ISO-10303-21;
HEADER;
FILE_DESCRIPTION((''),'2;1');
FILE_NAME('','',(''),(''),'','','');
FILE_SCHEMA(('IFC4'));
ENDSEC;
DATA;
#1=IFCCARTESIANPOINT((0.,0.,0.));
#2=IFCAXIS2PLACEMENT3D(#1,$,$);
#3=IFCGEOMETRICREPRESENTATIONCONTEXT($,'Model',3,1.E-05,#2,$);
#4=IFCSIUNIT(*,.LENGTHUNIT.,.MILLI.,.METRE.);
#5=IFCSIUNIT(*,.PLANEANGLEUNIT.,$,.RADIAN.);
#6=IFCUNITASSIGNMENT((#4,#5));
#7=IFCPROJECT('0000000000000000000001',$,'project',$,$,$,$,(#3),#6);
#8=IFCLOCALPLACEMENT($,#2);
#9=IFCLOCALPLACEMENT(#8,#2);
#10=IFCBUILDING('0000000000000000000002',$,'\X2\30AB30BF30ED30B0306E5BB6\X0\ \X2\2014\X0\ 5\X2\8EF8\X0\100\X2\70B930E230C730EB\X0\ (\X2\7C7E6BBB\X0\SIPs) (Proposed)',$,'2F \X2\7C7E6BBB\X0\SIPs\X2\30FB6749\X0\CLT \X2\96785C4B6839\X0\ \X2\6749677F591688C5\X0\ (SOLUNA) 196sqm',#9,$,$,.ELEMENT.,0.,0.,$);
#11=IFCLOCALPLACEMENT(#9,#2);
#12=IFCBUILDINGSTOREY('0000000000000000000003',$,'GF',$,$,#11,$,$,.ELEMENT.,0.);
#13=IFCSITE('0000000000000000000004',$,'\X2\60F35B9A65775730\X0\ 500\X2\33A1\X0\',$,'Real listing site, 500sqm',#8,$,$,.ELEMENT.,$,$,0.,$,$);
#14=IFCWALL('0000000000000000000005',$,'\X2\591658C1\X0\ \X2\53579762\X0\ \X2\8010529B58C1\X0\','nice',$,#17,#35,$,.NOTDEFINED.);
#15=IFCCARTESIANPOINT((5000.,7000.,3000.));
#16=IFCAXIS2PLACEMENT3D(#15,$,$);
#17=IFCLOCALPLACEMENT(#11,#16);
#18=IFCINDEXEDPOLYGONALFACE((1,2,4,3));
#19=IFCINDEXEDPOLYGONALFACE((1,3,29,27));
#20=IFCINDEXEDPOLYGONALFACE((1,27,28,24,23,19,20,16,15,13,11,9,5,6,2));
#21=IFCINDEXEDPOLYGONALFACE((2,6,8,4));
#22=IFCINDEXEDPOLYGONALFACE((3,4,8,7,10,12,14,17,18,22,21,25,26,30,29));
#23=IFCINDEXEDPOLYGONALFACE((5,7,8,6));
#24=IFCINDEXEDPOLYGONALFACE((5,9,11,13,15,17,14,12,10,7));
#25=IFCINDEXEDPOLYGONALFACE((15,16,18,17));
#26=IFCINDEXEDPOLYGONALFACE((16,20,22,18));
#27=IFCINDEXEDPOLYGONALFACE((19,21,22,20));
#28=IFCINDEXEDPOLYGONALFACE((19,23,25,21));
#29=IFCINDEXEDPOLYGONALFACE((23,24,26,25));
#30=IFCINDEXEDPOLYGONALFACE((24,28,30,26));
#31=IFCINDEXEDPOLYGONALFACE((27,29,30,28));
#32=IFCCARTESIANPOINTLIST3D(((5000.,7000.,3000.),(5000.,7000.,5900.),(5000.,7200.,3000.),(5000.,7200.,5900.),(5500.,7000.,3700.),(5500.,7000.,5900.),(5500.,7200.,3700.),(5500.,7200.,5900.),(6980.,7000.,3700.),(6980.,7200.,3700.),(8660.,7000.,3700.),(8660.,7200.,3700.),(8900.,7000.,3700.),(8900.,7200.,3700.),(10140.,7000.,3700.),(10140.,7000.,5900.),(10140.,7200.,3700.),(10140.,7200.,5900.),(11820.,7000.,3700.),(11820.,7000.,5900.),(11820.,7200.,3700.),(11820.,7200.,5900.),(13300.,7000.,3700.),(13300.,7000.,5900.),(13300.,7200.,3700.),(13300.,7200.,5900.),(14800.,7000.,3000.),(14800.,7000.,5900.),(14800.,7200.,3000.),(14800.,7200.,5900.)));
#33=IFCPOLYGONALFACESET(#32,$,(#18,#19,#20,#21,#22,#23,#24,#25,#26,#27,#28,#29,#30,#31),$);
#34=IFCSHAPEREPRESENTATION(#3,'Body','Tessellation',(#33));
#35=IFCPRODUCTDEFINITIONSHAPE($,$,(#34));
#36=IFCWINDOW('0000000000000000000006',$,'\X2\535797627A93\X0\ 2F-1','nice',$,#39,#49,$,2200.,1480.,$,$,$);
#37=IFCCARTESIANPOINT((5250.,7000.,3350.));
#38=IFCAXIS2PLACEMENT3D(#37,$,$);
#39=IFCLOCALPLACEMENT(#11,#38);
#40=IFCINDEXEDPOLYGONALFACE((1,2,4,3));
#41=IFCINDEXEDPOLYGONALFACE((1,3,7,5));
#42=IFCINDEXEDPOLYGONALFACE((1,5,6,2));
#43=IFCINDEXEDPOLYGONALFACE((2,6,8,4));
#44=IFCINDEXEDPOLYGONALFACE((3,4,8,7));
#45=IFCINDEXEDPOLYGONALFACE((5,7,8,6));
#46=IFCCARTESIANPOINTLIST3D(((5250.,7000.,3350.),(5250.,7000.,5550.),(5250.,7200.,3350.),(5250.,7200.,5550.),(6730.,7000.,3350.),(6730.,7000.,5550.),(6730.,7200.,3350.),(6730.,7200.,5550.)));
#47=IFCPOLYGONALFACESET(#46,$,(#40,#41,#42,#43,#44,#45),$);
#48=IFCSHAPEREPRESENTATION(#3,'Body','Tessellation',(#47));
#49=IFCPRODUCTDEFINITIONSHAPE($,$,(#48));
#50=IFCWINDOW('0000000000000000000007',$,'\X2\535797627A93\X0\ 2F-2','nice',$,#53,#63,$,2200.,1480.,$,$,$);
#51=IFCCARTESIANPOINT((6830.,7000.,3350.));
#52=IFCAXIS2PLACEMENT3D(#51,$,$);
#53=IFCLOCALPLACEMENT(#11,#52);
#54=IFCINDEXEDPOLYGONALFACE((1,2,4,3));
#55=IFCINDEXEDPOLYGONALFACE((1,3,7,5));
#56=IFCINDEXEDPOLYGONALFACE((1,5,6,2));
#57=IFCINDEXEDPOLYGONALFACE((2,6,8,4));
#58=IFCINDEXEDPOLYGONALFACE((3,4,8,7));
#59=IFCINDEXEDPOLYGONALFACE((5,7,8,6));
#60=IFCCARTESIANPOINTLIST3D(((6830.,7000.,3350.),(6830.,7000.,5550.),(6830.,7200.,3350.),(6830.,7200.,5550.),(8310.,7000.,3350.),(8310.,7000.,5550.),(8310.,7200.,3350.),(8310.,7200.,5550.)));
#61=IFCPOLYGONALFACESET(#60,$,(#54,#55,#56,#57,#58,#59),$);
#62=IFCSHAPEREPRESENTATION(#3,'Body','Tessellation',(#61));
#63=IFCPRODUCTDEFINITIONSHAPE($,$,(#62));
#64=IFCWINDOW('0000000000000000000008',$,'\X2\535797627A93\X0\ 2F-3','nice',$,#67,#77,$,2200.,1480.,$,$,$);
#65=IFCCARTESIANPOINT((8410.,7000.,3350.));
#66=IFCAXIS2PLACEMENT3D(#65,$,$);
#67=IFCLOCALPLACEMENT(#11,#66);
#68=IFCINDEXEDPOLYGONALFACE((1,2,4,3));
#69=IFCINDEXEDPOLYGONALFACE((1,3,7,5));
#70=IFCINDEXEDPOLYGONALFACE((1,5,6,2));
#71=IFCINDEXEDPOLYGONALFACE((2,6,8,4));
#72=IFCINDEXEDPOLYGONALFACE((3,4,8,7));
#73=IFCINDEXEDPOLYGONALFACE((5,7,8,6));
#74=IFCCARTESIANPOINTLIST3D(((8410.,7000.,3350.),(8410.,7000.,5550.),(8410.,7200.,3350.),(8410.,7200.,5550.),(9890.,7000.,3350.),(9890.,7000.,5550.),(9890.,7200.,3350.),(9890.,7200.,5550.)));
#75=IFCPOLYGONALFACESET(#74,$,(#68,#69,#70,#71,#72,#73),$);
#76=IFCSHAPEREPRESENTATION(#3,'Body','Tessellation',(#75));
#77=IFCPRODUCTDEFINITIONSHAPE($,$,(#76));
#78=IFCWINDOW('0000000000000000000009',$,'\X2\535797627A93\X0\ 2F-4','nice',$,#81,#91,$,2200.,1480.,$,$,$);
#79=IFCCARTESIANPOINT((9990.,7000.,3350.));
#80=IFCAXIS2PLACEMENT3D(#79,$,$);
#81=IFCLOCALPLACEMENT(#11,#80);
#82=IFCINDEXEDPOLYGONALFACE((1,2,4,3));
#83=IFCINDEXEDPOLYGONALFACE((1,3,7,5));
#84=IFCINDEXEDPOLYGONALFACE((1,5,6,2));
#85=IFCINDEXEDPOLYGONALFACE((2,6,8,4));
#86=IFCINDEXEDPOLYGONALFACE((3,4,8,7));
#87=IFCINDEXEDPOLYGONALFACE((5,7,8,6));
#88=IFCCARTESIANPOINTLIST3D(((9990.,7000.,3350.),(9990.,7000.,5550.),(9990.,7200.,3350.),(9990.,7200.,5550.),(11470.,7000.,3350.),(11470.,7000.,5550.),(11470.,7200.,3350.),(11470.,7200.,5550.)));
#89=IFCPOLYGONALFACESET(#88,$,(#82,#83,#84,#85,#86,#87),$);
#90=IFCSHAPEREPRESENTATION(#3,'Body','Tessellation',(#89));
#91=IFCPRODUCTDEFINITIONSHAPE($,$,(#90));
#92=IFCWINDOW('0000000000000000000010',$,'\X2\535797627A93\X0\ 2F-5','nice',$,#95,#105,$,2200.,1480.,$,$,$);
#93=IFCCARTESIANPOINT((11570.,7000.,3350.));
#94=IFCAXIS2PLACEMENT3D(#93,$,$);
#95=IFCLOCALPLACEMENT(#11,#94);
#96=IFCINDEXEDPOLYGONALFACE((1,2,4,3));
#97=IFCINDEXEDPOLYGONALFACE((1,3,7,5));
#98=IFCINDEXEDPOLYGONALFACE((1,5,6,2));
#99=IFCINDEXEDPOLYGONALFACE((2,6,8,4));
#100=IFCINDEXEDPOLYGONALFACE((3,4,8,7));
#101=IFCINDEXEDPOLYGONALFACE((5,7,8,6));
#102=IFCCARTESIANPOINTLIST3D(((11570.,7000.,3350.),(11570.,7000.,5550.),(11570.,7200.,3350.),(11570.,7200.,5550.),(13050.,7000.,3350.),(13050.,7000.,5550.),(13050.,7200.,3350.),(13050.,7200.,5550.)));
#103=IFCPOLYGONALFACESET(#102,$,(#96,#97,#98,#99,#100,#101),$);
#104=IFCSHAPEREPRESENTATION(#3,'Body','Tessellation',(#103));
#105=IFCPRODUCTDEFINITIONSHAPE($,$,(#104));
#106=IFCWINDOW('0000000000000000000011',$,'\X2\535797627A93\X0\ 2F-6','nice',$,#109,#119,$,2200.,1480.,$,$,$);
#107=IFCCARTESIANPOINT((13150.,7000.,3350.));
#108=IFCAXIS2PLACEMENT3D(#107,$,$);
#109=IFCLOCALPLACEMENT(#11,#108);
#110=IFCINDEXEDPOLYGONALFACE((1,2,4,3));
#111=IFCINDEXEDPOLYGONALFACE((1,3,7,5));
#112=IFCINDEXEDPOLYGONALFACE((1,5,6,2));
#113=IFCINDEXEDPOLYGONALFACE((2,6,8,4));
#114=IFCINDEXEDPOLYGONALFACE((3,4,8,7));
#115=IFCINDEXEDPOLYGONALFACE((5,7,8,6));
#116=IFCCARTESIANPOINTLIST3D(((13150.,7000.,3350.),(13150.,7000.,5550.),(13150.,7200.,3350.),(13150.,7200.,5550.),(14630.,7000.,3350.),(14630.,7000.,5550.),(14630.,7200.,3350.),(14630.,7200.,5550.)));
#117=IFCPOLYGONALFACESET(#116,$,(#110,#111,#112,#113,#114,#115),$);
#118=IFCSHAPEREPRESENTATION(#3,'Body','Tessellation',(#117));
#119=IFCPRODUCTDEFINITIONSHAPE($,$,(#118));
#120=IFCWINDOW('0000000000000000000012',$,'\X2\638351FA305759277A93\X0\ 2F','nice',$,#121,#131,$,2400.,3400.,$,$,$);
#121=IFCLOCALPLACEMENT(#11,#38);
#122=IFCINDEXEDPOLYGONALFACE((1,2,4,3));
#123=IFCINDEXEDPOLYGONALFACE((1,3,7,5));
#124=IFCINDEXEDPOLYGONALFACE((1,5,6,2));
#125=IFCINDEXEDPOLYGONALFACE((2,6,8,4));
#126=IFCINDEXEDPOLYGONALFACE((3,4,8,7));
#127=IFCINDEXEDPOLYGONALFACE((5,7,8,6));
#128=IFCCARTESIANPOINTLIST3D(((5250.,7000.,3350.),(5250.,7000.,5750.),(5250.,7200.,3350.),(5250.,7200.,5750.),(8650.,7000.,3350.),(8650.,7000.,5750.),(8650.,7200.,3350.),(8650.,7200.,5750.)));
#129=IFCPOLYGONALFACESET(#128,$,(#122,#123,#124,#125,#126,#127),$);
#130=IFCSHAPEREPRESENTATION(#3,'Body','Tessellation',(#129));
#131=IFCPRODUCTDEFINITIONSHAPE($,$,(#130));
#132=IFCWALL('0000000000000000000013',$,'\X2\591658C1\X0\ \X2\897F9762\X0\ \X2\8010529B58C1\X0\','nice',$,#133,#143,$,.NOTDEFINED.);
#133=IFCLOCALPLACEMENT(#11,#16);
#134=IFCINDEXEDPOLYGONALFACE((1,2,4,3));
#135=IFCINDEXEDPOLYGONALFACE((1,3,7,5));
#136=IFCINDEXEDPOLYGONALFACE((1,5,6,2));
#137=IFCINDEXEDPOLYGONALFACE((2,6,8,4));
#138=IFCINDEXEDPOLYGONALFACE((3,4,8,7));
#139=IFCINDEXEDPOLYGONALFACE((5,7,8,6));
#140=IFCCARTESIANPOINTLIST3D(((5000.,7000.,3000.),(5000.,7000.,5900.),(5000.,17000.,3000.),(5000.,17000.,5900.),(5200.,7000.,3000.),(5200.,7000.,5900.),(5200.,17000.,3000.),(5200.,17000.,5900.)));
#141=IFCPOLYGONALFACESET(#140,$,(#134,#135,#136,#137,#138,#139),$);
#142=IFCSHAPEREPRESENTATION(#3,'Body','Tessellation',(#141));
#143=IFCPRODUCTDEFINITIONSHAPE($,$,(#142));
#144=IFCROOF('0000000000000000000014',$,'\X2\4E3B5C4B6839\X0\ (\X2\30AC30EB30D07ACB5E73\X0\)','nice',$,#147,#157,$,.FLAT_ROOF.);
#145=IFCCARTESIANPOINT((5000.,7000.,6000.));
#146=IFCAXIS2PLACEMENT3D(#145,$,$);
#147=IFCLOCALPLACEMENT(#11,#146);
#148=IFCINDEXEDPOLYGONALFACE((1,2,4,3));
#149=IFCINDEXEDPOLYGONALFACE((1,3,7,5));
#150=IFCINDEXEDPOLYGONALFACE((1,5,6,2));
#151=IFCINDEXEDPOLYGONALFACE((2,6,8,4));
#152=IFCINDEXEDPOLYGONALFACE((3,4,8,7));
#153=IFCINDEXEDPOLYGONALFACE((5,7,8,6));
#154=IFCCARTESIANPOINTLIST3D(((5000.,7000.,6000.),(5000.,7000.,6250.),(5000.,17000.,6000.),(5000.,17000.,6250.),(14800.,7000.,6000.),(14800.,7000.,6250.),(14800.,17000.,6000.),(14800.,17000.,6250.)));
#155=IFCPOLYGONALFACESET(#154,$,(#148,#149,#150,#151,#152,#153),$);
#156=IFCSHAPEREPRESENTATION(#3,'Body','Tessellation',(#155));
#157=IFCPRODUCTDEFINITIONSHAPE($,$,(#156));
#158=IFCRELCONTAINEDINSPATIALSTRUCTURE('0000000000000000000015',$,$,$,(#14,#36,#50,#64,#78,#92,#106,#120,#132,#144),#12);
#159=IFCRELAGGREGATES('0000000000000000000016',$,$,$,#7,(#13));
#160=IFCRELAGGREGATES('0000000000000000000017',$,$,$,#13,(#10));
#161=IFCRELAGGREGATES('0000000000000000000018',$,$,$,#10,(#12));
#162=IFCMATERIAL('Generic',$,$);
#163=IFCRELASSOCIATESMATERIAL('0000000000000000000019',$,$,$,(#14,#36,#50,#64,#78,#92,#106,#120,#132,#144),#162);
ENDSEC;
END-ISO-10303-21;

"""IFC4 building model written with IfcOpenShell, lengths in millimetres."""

from ifc_helpers import new_model, si_unit, frame, frame_2d, origin, place, context, project, spatial, rectangle, extrude, material, element, fill, save


model = new_model("IFC4")

# Units and contexts
model_context = context("Model", 3, precision=1e-05, world=origin())
ifc_project = project(units=[si_unit("LENGTHUNIT", "METRE", prefix="MILLI"), si_unit("PLANEANGLEUNIT", "RADIAN")], contexts=[model_context])

# Site, building, storey
site_placement = place(None, origin())
site = spatial("IfcSite", under=ifc_project, at=site_placement, Name="想定敷地 500㎡", ObjectType="Real listing site, 500sqm", CompositionType="ELEMENT", RefElevation=0.0)
building_placement = place(site_placement, origin())
building = spatial("IfcBuilding", under=site, at=building_placement, Name="カタログの家 — 5軸100点モデル (籾殻SIPs) (Proposed)", ObjectType="2F 籾殻SIPs・杉CLT 陸屋根 杉板外装 (SOLUNA) 196sqm", CompositionType="ELEMENT", ElevationOfRefHeight=0.0, ElevationOfTerrain=0.0)
storey_placement = place(building_placement, origin())
storey = spatial("IfcBuildingStorey", under=building, at=storey_placement, Name="GF", CompositionType="ELEMENT", Elevation=0.0)

# Shared definitions
ifc_material = material(Name="Generic")

# Wall, openings, windows
wall_1_placement = place(storey_placement, frame((5000.0, 7000.0, 3000.0)))
wall_1 = element("IfcWall", 1, at=wall_1_placement, inside=storey, material=ifc_material, Name="外壁 南面 耐力壁", Description="nice", PredefinedType="NOTDEFINED", context=model_context, shape_type="SweptSolid", body=[
    extrude(rectangle(XDim=9800.0, YDim=200.0, at=frame_2d((4900.0, 100.0))), frame((5000.0, 7000.0, 3000.0)), (0.0, 0.0, 1.0), 2900.0),
])
opening_1_placement = place(storey_placement, frame((5250.0, 7000.0, 3350.0)))
opening_1 = element("IfcOpeningElement", 2, at=opening_1_placement, cuts=wall_1, PredefinedType="NOTDEFINED", context=model_context, shape_type="SweptSolid", body=[
    extrude(rectangle(XDim=1480.0, YDim=200.0, at=frame_2d((740.0, 100.0))), frame((5250.0, 7000.0, 3350.0)), (0.0, 0.0, 1.0), 2200.0),
])
opening_2_placement = place(storey_placement, frame((6830.0, 7000.0, 3350.0)))
opening_2 = element("IfcOpeningElement", 3, at=opening_2_placement, cuts=wall_1, PredefinedType="NOTDEFINED", context=model_context, shape_type="SweptSolid", body=[
    extrude(rectangle(XDim=1480.0, YDim=200.0, at=frame_2d((740.0, 100.0))), frame((6830.0, 7000.0, 3350.0)), (0.0, 0.0, 1.0), 2200.0),
])
opening_3_placement = place(storey_placement, frame((8410.0, 7000.0, 3350.0)))
opening_3 = element("IfcOpeningElement", 4, at=opening_3_placement, cuts=wall_1, PredefinedType="NOTDEFINED", context=model_context, shape_type="SweptSolid", body=[
    extrude(rectangle(XDim=1480.0, YDim=200.0, at=frame_2d((740.0, 100.0))), frame((8410.0, 7000.0, 3350.0)), (0.0, 0.0, 1.0), 2200.0),
])
opening_4_placement = place(storey_placement, frame((9990.0, 7000.0, 3350.0)))
opening_4 = element("IfcOpeningElement", 5, at=opening_4_placement, cuts=wall_1, PredefinedType="NOTDEFINED", context=model_context, shape_type="SweptSolid", body=[
    extrude(rectangle(XDim=1480.0, YDim=200.0, at=frame_2d((740.0, 100.0))), frame((9990.0, 7000.0, 3350.0)), (0.0, 0.0, 1.0), 2200.0),
])
opening_5_placement = place(storey_placement, frame((11570.0, 7000.0, 3350.0)))
opening_5 = element("IfcOpeningElement", 6, at=opening_5_placement, cuts=wall_1, PredefinedType="NOTDEFINED", context=model_context, shape_type="SweptSolid", body=[
    extrude(rectangle(XDim=1480.0, YDim=200.0, at=frame_2d((740.0, 100.0))), frame((11570.0, 7000.0, 3350.0)), (0.0, 0.0, 1.0), 2200.0),
])
opening_6_placement = place(storey_placement, frame((13150.0, 7000.0, 3350.0)))
opening_6 = element("IfcOpeningElement", 7, at=opening_6_placement, cuts=wall_1, PredefinedType="NOTDEFINED", context=model_context, shape_type="SweptSolid", body=[
    extrude(rectangle(XDim=1480.0, YDim=200.0, at=frame_2d((740.0, 100.0))), frame((13150.0, 7000.0, 3350.0)), (0.0, 0.0, 1.0), 2200.0),
])
opening_7_placement = place(storey_placement, frame((5250.0, 7000.0, 3350.0)))
opening_7 = element("IfcOpeningElement", 8, at=opening_7_placement, cuts=wall_1, PredefinedType="NOTDEFINED", context=model_context, shape_type="SweptSolid", body=[
    extrude(rectangle(XDim=3400.0, YDim=200.0, at=frame_2d((1700.0, 100.0))), frame((5250.0, 7000.0, 3350.0)), (0.0, 0.0, 1.0), 2400.0),
])
window_1_placement = place(storey_placement, frame((5250.0, 7000.0, 3350.0)))
window_1 = element("IfcWindow", 9, at=window_1_placement, inside=storey, material=ifc_material, Name="南面窓 2F-1", Description="nice", OverallHeight=2200.0, OverallWidth=1480.0, context=model_context, shape_type="SweptSolid", body=[
    extrude(rectangle(XDim=1480.0, YDim=200.0, at=frame_2d((740.0, 100.0))), frame((5250.0, 7000.0, 3350.0)), (0.0, 0.0, 1.0), 2200.0),
])
fill(opening_1, window_1)
window_2_placement = place(storey_placement, frame((6830.0, 7000.0, 3350.0)))
window_2 = element("IfcWindow", 10, at=window_2_placement, inside=storey, material=ifc_material, Name="南面窓 2F-2", Description="nice", OverallHeight=2200.0, OverallWidth=1480.0, context=model_context, shape_type="SweptSolid", body=[
    extrude(rectangle(XDim=1480.0, YDim=200.0, at=frame_2d((740.0, 100.0))), frame((6830.0, 7000.0, 3350.0)), (0.0, 0.0, 1.0), 2200.0),
])
fill(opening_2, window_2)
window_3_placement = place(storey_placement, frame((8410.0, 7000.0, 3350.0)))
window_3 = element("IfcWindow", 11, at=window_3_placement, inside=storey, material=ifc_material, Name="南面窓 2F-3", Description="nice", OverallHeight=2200.0, OverallWidth=1480.0, context=model_context, shape_type="SweptSolid", body=[
    extrude(rectangle(XDim=1480.0, YDim=200.0, at=frame_2d((740.0, 100.0))), frame((8410.0, 7000.0, 3350.0)), (0.0, 0.0, 1.0), 2200.0),
])
fill(opening_3, window_3)
window_4_placement = place(storey_placement, frame((9990.0, 7000.0, 3350.0)))
window_4 = element("IfcWindow", 12, at=window_4_placement, inside=storey, material=ifc_material, Name="南面窓 2F-4", Description="nice", OverallHeight=2200.0, OverallWidth=1480.0, context=model_context, shape_type="SweptSolid", body=[
    extrude(rectangle(XDim=1480.0, YDim=200.0, at=frame_2d((740.0, 100.0))), frame((9990.0, 7000.0, 3350.0)), (0.0, 0.0, 1.0), 2200.0),
])
fill(opening_4, window_4)
window_5_placement = place(storey_placement, frame((11570.0, 7000.0, 3350.0)))
window_5 = element("IfcWindow", 13, at=window_5_placement, inside=storey, material=ifc_material, Name="南面窓 2F-5", Description="nice", OverallHeight=2200.0, OverallWidth=1480.0, context=model_context, shape_type="SweptSolid", body=[
    extrude(rectangle(XDim=1480.0, YDim=200.0, at=frame_2d((740.0, 100.0))), frame((11570.0, 7000.0, 3350.0)), (0.0, 0.0, 1.0), 2200.0),
])
fill(opening_5, window_5)
window_6_placement = place(storey_placement, frame((13150.0, 7000.0, 3350.0)))
window_6 = element("IfcWindow", 14, at=window_6_placement, inside=storey, material=ifc_material, Name="南面窓 2F-6", Description="nice", OverallHeight=2200.0, OverallWidth=1480.0, context=model_context, shape_type="SweptSolid", body=[
    extrude(rectangle(XDim=1480.0, YDim=200.0, at=frame_2d((740.0, 100.0))), frame((13150.0, 7000.0, 3350.0)), (0.0, 0.0, 1.0), 2200.0),
])
fill(opening_6, window_6)
window_7_placement = place(storey_placement, frame((5250.0, 7000.0, 3350.0)))
window_7 = element("IfcWindow", 15, at=window_7_placement, inside=storey, material=ifc_material, Name="掃出し大窓 2F", Description="nice", OverallHeight=2400.0, OverallWidth=3400.0, context=model_context, shape_type="SweptSolid", body=[
    extrude(rectangle(XDim=3400.0, YDim=200.0, at=frame_2d((1700.0, 100.0))), frame((5250.0, 7000.0, 3350.0)), (0.0, 0.0, 1.0), 2400.0),
])
fill(opening_7, window_7)

# Wall
wall_2_placement = place(storey_placement, frame((5000.0, 7000.0, 3000.0)))
element("IfcWall", 16, at=wall_2_placement, inside=storey, material=ifc_material, Name="外壁 西面 耐力壁", Description="nice", PredefinedType="NOTDEFINED", context=model_context, shape_type="SweptSolid", body=[
    extrude(rectangle(XDim=200.0, YDim=10000.0, at=frame_2d((100.0, 5000.0))), frame((5000.0, 7000.0, 3000.0)), (0.0, 0.0, 1.0), 2900.0),
])

# Roof
roof_placement = place(storey_placement, frame((5000.0, 7000.0, 6000.0)))
element("IfcRoof", 17, at=roof_placement, inside=storey, material=ifc_material, Name="主屋根 (ガルバ立平)", Description="nice", PredefinedType="FLAT_ROOF", context=model_context, shape_type="SweptSolid", body=[
    extrude(rectangle(XDim=9800.0, YDim=10000.0, at=frame_2d((4900.0, 5000.0))), frame((5000.0, 7000.0, 6000.0)), (0.0, 0.0, 1.0), 250.0),
])

save(model, "model.ifc")
